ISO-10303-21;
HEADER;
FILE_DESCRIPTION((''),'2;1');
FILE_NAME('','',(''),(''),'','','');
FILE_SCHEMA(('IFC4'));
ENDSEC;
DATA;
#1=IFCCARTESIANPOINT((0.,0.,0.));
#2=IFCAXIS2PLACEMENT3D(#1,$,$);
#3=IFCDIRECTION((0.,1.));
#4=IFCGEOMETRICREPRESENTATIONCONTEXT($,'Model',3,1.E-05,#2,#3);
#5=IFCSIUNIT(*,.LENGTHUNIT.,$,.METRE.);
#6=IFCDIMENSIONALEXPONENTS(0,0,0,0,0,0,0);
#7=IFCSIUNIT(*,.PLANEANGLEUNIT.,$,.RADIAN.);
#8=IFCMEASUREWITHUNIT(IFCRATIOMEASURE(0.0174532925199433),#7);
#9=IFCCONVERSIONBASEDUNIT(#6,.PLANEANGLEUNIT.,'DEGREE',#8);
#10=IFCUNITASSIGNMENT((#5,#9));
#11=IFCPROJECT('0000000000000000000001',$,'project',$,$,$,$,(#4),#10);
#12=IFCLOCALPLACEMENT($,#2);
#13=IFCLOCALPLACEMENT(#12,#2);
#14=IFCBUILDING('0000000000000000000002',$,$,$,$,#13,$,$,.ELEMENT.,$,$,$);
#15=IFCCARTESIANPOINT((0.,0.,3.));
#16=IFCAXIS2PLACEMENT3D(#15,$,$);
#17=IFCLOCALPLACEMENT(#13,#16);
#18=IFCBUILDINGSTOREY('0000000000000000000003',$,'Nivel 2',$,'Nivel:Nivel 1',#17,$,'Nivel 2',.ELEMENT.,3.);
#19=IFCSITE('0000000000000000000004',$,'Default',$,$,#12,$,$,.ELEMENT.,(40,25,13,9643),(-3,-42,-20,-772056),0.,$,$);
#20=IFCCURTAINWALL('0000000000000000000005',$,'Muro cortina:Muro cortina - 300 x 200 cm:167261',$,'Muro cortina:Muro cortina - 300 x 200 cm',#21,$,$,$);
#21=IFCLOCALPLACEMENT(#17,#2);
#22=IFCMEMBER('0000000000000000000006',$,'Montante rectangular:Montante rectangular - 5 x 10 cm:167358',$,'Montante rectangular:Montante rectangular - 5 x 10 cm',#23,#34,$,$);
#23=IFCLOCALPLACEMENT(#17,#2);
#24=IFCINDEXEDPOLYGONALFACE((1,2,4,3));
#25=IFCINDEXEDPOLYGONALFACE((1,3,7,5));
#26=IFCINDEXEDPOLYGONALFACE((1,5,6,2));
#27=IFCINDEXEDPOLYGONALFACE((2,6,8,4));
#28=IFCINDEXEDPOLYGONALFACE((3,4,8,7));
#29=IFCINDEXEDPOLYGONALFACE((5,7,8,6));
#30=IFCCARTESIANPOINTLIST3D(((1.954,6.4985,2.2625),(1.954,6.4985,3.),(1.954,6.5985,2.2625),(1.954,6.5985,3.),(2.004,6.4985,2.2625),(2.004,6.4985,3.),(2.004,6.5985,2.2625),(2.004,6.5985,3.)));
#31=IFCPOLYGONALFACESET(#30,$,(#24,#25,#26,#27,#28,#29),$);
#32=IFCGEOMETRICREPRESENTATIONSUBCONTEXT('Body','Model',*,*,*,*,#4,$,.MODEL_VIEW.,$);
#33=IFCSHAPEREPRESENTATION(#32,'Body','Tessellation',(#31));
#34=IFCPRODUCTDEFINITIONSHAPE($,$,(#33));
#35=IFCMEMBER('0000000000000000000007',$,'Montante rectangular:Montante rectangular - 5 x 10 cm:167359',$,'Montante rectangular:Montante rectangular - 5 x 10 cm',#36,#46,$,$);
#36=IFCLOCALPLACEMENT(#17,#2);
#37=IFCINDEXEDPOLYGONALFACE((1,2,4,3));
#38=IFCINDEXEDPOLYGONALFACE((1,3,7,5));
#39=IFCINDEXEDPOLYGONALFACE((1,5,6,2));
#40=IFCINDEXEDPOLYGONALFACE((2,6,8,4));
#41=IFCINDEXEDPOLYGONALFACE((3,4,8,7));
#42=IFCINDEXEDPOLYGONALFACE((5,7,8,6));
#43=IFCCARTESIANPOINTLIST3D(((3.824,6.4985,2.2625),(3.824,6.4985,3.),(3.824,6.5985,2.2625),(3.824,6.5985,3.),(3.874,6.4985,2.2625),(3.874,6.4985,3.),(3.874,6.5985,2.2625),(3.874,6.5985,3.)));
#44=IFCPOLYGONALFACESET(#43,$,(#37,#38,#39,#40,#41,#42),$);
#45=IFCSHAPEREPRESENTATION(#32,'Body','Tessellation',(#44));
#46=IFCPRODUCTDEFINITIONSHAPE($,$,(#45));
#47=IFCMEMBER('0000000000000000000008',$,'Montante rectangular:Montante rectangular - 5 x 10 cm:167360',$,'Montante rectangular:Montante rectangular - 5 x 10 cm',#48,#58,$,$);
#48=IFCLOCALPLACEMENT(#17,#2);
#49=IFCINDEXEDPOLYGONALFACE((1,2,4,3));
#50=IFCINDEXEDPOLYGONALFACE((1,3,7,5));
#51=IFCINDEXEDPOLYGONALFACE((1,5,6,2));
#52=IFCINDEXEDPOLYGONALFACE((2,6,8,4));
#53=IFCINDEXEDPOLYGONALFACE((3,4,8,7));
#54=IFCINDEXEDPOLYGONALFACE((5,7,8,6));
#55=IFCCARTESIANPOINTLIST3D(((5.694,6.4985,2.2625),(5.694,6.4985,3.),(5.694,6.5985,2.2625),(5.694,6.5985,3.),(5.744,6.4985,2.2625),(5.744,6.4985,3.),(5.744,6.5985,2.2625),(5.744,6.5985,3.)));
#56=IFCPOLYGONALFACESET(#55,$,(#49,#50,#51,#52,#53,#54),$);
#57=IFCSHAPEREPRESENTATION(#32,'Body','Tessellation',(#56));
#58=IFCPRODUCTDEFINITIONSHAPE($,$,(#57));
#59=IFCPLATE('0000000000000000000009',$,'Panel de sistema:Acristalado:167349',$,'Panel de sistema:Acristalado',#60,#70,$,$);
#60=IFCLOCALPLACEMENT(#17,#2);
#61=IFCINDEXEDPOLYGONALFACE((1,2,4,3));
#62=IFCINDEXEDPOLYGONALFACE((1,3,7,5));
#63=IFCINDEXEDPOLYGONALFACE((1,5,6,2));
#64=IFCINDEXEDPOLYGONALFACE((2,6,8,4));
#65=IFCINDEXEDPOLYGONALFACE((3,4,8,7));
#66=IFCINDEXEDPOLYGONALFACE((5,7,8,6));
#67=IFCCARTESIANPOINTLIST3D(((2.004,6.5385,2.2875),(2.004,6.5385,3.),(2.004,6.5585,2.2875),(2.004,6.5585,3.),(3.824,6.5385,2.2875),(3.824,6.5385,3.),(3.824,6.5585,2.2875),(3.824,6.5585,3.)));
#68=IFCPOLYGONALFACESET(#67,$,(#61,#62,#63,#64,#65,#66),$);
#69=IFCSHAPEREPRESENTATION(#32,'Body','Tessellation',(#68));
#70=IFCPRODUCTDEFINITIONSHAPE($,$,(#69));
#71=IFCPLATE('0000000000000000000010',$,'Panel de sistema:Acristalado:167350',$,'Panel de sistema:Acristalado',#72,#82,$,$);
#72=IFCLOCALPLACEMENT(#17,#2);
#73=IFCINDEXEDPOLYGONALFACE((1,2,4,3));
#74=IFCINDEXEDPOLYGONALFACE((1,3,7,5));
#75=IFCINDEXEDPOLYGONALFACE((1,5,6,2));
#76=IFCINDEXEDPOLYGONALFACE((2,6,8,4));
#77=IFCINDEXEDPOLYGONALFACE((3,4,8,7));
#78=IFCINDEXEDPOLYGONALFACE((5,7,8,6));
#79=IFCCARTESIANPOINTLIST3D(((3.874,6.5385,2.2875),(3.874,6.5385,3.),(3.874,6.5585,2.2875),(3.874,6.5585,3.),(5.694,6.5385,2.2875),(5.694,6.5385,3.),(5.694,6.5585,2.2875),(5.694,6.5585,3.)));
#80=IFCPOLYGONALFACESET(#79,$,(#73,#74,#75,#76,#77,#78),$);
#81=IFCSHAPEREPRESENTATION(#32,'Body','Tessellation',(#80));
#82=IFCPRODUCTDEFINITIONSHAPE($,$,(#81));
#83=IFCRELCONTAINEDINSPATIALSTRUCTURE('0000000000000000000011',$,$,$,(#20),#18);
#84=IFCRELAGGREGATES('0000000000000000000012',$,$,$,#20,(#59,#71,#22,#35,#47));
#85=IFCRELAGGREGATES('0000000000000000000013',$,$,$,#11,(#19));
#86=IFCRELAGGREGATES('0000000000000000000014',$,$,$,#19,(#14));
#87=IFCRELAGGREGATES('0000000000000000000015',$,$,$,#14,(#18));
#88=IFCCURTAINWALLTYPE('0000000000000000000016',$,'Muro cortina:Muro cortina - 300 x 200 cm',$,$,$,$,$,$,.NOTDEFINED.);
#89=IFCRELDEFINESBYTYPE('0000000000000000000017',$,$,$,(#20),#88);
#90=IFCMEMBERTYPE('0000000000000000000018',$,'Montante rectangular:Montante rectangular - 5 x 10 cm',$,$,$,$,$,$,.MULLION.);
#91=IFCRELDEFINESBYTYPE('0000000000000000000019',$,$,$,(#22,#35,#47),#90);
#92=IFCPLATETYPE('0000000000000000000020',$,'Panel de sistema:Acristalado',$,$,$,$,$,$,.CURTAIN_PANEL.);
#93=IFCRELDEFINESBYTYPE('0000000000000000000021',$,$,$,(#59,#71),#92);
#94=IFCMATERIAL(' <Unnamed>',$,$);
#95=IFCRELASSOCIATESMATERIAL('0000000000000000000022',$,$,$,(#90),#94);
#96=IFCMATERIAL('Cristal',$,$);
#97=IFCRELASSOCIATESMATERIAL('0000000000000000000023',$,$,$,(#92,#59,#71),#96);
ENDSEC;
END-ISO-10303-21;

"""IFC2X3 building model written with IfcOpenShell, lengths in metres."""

from ifc_helpers import new_model, entity, si_unit, converted_unit, direction, frame, origin, origin_2d_with_axis, place, context, subcontext, project, spatial, rectangle, extrude, source, transform, mapped, material, type_object, type_shapes, element, aggregate, save


model = new_model("IFC2X3")

# Units and contexts
model_context = context("Model", 3, precision=1e-05, world=origin(), true_north=direction((0.0, 1.0)))
body_context = subcontext(model_context, "Body", "Model", "MODEL_VIEW")
ifc_project = project(units=[si_unit("LENGTHUNIT", "METRE"), converted_unit("PLANEANGLEUNIT", "DEGREE", entity("IfcRatioMeasure", 0.0174532925199433), si_unit("PLANEANGLEUNIT", "RADIAN"), dimensions=[0, 0, 0, 0, 0, 0, 0])], contexts=[model_context])

# Site, building, storey
site_placement = place(None, origin())
site = spatial("IfcSite", under=ifc_project, at=site_placement, Name="Default", CompositionType="ELEMENT", RefLatitude=(40, 25, 13, 9643), RefLongitude=(-3, -42, -20, -772056), RefElevation=0.0)
building_placement = place(site_placement, origin())
building = spatial("IfcBuilding", under=site, at=building_placement, CompositionType="ELEMENT")
storey_placement = place(building_placement, frame((0.0, 0.0, 3.0)))
storey = spatial("IfcBuildingStorey", under=building, at=storey_placement, Name="Nivel 2", ObjectType="Nivel:Nivel 1", LongName="Nivel 2", CompositionType="ELEMENT", Elevation=3.0)

# Curtain wall, members, plates
curtain_wall_type = type_object("IfcCurtainWallType", Name="Muro cortina:Muro cortina - 300 x 200 cm", PredefinedType="NOTDEFINED")
curtain_wall_placement = place(storey_placement, frame((0.0, 0.0, -3.0)))
curtain_wall = element("IfcCurtainWall", 1, at=curtain_wall_placement, inside=storey, type_object=curtain_wall_type, Name="Muro cortina:Muro cortina - 300 x 200 cm:167261", ObjectType="Muro cortina:Muro cortina - 300 x 200 cm")
ifc_material_1 = material(Name=" <Unnamed>")
member_type_1 = type_object("IfcMemberType", Name="Montante rectangular:Montante rectangular - 5 x 10 cm", PredefinedType="MULLION", material=ifc_material_1)
shared_shape_1 = source(origin(), body_context, "Body", "SweptSolid", [
    extrude(rectangle(XDim=0.1, YDim=0.05, at=origin_2d_with_axis()), frame((0.0, 0.0, -0.7375), z_axis=(0.0, 0.0, 1.0), x_axis=(0.0, -1.0, 0.0)), (0.0, 0.0, 1.0), 0.7375),
])
type_shapes(member_type_1, [shared_shape_1])
member_1_placement = place(storey_placement, frame((1.979, 6.5485, 2.2625), z_axis=(0.0, 0.0, -1.0), x_axis=(1.0, 0.0, 0.0)))
member_1 = element("IfcMember", 2, at=member_1_placement, type_object=member_type_1, Name="Montante rectangular:Montante rectangular - 5 x 10 cm:167358", ObjectType="Montante rectangular:Montante rectangular - 5 x 10 cm", context=body_context, shape_type="MappedRepresentation", body=[
    mapped(shared_shape_1, transform((0.0, 0.0, 0.0), scale=1.0)),
])
member_2_placement = place(storey_placement, frame((3.849, 6.5485, 2.2625), z_axis=(0.0, 0.0, -1.0), x_axis=(1.0, 0.0, 0.0)))
member_2 = element("IfcMember", 3, at=member_2_placement, type_object=member_type_1, Name="Montante rectangular:Montante rectangular - 5 x 10 cm:167359", ObjectType="Montante rectangular:Montante rectangular - 5 x 10 cm", context=body_context, shape_type="MappedRepresentation", body=[
    mapped(shared_shape_1, transform((0.0, 0.0, 0.0), scale=1.0)),
])
member_3_placement = place(storey_placement, frame((5.719, 6.5485, 2.2625), z_axis=(0.0, 0.0, -1.0), x_axis=(1.0, 0.0, 0.0)))
member_3 = element("IfcMember", 4, at=member_3_placement, type_object=member_type_1, Name="Montante rectangular:Montante rectangular - 5 x 10 cm:167360", ObjectType="Montante rectangular:Montante rectangular - 5 x 10 cm", context=body_context, shape_type="MappedRepresentation", body=[
    mapped(shared_shape_1, transform((0.0, 0.0, 0.0), scale=1.0)),
])
ifc_material_2 = material(Name="Cristal")
plate_type = type_object("IfcPlateType", Name="Panel de sistema:Acristalado", PredefinedType="CURTAIN_PANEL", material=ifc_material_2)
shared_shape_2 = source(origin(), body_context, "Body", "SweptSolid", [
    extrude(rectangle(XDim=0.02, YDim=1.82, at=origin_2d_with_axis()), frame((0.0, 0.0, 0.0), z_axis=(0.0, 0.0, 1.0), x_axis=(0.0, 1.0, 0.0)), (0.0, 0.0, 1.0), 0.7125),
])
type_shapes(plate_type, [shared_shape_2])
plate_1_placement = place(curtain_wall_placement, frame((2.914, 6.5485, 5.2875)))
plate_1 = element("IfcPlate", 5, at=plate_1_placement, type_object=plate_type, material=ifc_material_2, Name="Panel de sistema:Acristalado:167349", ObjectType="Panel de sistema:Acristalado", context=body_context, shape_type="MappedRepresentation", body=[
    mapped(shared_shape_2, transform((0.0, 0.0, 0.0), scale=1.0)),
])
plate_2_placement = place(curtain_wall_placement, frame((4.784, 6.5485, 5.2875)))
plate_2 = element("IfcPlate", 6, at=plate_2_placement, type_object=plate_type, material=ifc_material_2, Name="Panel de sistema:Acristalado:167350", ObjectType="Panel de sistema:Acristalado", context=body_context, shape_type="MappedRepresentation", body=[
    mapped(shared_shape_2, transform((0.0, 0.0, 0.0), scale=1.0)),
])
aggregate(curtain_wall, [plate_1, plate_2, member_1, member_2, member_3])

save(model, "model.ifc")
